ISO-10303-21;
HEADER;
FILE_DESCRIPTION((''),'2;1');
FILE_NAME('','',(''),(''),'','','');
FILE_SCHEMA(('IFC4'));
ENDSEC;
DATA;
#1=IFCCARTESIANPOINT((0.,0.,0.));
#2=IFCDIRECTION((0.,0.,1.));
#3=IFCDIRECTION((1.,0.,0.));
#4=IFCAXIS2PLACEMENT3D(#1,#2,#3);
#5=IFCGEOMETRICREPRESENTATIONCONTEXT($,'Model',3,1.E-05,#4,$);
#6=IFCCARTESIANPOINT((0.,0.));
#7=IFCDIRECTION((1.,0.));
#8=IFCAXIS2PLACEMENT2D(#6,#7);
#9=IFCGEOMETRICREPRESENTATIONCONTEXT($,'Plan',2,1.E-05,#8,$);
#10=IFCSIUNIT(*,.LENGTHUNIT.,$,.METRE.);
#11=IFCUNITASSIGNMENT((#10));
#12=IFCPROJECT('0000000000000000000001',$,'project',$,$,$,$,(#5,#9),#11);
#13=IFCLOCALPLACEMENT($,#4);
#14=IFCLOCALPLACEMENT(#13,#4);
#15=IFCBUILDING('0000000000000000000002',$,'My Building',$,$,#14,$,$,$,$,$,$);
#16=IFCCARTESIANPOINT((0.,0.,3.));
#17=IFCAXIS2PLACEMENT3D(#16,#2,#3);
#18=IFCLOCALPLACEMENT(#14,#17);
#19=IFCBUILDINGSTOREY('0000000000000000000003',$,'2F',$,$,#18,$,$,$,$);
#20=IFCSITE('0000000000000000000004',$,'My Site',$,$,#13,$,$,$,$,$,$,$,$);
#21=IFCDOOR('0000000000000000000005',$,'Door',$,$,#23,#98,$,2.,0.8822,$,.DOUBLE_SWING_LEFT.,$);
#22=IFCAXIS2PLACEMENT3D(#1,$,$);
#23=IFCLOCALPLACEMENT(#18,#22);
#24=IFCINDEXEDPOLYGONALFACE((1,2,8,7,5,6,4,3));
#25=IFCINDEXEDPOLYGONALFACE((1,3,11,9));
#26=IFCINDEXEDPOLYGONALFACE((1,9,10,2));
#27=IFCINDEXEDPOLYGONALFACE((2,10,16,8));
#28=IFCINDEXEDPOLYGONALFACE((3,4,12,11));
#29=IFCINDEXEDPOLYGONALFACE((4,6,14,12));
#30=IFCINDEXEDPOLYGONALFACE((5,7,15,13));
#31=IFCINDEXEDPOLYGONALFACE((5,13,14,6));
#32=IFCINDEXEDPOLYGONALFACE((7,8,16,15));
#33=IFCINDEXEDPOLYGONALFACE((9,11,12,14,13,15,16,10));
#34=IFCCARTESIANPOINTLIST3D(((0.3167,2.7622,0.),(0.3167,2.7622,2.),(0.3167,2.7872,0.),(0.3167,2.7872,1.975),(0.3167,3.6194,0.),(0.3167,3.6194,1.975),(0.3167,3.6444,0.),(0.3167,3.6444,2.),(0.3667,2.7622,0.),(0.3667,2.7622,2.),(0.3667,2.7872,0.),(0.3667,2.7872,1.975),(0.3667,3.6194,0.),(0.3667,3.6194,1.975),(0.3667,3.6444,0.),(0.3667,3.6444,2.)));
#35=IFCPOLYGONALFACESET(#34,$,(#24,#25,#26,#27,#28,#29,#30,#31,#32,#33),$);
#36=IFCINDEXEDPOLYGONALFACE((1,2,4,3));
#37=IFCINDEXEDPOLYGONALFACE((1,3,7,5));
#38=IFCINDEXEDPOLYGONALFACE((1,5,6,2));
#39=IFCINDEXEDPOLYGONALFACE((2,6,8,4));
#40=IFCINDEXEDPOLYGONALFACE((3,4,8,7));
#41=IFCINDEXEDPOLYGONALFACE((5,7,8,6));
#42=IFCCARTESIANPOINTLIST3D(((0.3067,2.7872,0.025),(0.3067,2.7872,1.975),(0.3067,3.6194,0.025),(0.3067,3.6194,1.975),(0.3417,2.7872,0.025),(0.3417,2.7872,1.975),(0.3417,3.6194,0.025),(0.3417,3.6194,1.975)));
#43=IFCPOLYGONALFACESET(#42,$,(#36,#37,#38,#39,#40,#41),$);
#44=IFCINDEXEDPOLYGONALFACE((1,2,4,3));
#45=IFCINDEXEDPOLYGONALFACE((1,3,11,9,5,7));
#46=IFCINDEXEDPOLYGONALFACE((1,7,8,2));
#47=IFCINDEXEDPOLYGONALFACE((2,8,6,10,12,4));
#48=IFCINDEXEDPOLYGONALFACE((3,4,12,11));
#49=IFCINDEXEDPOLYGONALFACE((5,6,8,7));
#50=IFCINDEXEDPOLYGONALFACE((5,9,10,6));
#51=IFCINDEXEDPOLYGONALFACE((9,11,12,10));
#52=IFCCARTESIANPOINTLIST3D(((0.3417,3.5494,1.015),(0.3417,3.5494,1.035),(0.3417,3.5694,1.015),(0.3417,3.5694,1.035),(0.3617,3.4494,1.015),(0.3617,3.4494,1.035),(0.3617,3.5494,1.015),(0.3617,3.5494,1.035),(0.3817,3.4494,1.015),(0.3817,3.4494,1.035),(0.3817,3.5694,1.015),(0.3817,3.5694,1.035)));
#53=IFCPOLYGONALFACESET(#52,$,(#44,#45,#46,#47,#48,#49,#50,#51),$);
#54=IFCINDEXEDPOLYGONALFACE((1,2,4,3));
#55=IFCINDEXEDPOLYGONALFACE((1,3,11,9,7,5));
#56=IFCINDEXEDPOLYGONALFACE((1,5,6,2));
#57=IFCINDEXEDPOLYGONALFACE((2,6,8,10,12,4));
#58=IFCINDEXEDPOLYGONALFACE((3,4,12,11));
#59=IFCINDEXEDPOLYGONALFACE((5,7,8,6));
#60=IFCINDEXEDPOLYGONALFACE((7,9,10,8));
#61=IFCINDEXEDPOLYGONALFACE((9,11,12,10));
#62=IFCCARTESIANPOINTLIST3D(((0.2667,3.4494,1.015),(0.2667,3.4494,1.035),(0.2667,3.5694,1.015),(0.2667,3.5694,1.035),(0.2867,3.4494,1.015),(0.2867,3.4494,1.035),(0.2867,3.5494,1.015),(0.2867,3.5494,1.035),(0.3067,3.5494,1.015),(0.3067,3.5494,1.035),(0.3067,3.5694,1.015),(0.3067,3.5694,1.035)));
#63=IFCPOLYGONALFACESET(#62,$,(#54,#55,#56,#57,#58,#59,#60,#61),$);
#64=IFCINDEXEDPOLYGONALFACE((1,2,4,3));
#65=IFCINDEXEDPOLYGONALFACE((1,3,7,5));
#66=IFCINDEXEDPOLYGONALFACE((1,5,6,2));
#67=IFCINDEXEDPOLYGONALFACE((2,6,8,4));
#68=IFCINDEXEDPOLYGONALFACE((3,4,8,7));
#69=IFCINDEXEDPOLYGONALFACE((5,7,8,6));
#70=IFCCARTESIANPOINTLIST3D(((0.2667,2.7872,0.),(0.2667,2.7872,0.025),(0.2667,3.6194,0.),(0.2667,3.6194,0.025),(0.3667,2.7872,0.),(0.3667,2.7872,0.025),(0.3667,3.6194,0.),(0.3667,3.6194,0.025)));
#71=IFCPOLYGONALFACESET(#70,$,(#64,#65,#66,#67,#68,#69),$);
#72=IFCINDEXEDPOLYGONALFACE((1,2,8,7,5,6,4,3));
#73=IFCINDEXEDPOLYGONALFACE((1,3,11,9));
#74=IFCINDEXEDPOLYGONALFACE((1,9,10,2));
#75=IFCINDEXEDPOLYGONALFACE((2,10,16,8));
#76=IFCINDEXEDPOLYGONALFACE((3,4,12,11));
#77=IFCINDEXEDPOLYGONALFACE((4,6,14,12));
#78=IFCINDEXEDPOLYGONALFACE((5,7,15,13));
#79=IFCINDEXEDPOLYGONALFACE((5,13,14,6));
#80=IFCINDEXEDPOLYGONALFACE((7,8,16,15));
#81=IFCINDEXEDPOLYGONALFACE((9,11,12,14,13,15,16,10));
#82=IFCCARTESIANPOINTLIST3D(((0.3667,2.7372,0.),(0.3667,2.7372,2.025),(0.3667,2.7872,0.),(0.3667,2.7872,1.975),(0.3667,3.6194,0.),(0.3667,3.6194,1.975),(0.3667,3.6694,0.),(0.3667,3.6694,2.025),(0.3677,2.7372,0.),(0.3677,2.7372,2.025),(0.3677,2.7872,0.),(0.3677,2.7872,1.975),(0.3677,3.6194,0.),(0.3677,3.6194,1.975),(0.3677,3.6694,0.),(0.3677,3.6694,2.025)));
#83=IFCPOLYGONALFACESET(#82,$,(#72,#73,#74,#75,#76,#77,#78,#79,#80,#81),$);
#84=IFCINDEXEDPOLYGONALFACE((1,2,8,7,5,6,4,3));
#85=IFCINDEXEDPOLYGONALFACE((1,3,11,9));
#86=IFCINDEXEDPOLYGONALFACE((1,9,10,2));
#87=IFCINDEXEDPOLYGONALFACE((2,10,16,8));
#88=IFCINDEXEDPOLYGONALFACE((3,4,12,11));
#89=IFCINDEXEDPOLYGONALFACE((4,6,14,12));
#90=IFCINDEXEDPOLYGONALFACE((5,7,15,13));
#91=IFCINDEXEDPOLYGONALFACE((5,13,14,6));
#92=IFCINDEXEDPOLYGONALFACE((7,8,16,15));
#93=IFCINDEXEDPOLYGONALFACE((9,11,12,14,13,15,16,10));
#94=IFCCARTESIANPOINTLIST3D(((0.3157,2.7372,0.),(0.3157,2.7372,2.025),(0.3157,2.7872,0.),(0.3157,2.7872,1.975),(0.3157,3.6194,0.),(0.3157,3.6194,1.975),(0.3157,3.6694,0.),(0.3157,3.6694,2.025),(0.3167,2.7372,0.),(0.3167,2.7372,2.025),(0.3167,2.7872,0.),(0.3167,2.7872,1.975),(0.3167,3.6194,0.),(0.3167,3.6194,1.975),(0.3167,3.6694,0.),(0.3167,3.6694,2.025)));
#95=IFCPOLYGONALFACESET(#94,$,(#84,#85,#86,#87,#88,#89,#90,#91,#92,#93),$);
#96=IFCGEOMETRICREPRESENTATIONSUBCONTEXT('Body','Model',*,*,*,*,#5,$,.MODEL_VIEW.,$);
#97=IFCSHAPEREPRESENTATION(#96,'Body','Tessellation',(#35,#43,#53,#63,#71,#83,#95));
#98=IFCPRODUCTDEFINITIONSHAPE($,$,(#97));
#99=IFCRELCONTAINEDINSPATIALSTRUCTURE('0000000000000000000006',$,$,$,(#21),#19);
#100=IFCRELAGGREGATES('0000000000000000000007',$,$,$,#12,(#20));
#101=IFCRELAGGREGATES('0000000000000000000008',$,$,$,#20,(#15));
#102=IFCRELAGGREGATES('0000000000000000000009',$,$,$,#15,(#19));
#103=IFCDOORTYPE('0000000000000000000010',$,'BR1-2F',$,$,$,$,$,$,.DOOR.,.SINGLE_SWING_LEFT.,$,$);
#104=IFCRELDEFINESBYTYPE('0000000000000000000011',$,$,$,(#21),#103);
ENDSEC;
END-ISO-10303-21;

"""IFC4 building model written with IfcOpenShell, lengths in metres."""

from ifc_helpers import new_model, entity, si_unit, frame, origin_with_axes, origin_2d_with_axis, place, context, subcontext, project, spatial, line, indexed_curve, outline, extrude, shape, source, transform, mapped, type_object, type_shapes, element, save


model = new_model("IFC4")

# Units and contexts
model_context = context("Model", 3, precision=1e-05, world=origin_with_axes())
plan_context = context("Plan", 2, precision=1e-05, world=origin_2d_with_axis())
body_context_1 = subcontext(model_context, "Body", "Model", "MODEL_VIEW")
body_context_2 = subcontext(plan_context, "Body", "Plan", "PLAN_VIEW")
ifc_project = project(units=[si_unit("LENGTHUNIT", "METRE")], contexts=[model_context, plan_context])

# Site, building, storey
site_placement = place(None, origin_with_axes())
site = spatial("IfcSite", under=ifc_project, at=site_placement, Name="My Site")
building_placement = place(site_placement, origin_with_axes())
building = spatial("IfcBuilding", under=site, at=building_placement, Name="My Building")
storey_placement = place(building_placement, frame((0.0, 0.0, 3.0), z_axis=(0.0, 0.0, 1.0), x_axis=(1.0, 0.0, 0.0)))
storey = spatial("IfcBuildingStorey", under=building, at=storey_placement, Name="2F")

# Door
door_type_1 = type_object("IfcDoorType", Name="BR1-2F", OperationType="SINGLE_SWING_LEFT", PredefinedType="DOOR")
shared_shape_1 = source(origin_with_axes(), body_context_1, "Body", "SweptSolid", [
    extrude(outline(indexed_curve([(0.0, 0.0), (0.0, 2.0), (0.8822, 2.0), (0.8822, 0.0), (0.8572, 0.0), (0.8572, 1.975), (0.025, 1.975), (0.025, 0.0)], segments=[line(1, 2, 3, 4, 5, 6, 7, 8, 1)])), frame((0.0, 0.0, 0.0), z_axis=(0.0, -1.0, 0.0), x_axis=(1.0, 0.0, 0.0)), (0.0, 0.0, -1.0), 0.05),
    extrude(outline(indexed_curve([(0.0, 0.0), (0.8322, 0.0), (0.8322, 0.035), (0.0, 0.035)], segments=[line(1, 2, 3, 4, 1)])), frame((0.025, 0.025, 0.025), z_axis=(0.0, 0.0, 1.0), x_axis=(1.0, 0.0, 0.0)), (0.0, 0.0, 1.0), 1.95),
    extrude(outline(indexed_curve([(0.0, 0.0), (0.0, -0.04), (-0.12, -0.04), (-0.12, -0.02), (-0.02, -0.02), (-0.02, 0.0)], segments=[line(1, 2, 3, 4, 5, 6, 1)])), frame((0.8072, 0.025, 1.015), z_axis=(0.0, 0.0, 1.0), x_axis=(1.0, 0.0, 0.0)), (0.0, 0.0, 1.0), 0.02),
    extrude(outline(indexed_curve([(0.0, 0.0), (0.0, 0.04), (-0.12, 0.04), (-0.12, 0.02), (-0.02, 0.02), (-0.02, 0.0)], segments=[line(1, 2, 3, 4, 5, 6, 1)])), frame((0.8072, 0.06, 1.015), z_axis=(0.0, 0.0, 1.0), x_axis=(1.0, 0.0, 0.0)), (0.0, 0.0, 1.0), 0.02),
    extrude(outline(indexed_curve([(0.0, 0.0), (0.8322, 0.0), (0.8322, 0.1), (0.0, 0.1)], segments=[line(1, 2, 3, 4, 1)])), frame((0.025, 0.0, 0.0), z_axis=(0.0, 0.0, 1.0), x_axis=(1.0, 0.0, 0.0)), (0.0, 0.0, 1.0), 0.025),
    extrude(outline(indexed_curve([(0.0, 0.0), (0.0, 2.025), (0.9322, 2.025), (0.9322, 0.0), (0.8822, 0.0), (0.8822, 1.975), (0.05, 1.975), (0.05, 0.0)], segments=[line(1, 2, 3, 4, 5, 6, 7, 8, 1)])), frame((-0.025, -0.001, 0.0), z_axis=(0.0, -1.0, 0.0), x_axis=(1.0, 0.0, 0.0)), (0.0, 0.0, -1.0), 0.001),
    extrude(outline(indexed_curve([(0.0, 0.0), (0.0, 2.025), (0.9322, 2.025), (0.9322, 0.0), (0.8822, 0.0), (0.8822, 1.975), (0.05, 1.975), (0.05, 0.0)], segments=[line(1, 2, 3, 4, 5, 6, 7, 8, 1)])), frame((-0.025, 0.05, 0.0), z_axis=(0.0, -1.0, 0.0), x_axis=(1.0, 0.0, 0.0)), (0.0, 0.0, -1.0), 0.001),
])
shared_shape_2 = source(origin_with_axes(), body_context_2, "Body", "Curve2D", [
    entity("IfcIndexedPolyCurve", entity("IfcCartesianPointList2D", [[0.0, 0.0], [0.025, 0.0], [0.025, 0.05], [0.0, 0.05]]), [entity("IfcLineIndex", [1, 2, 3, 4, 1])]),
    entity("IfcIndexedPolyCurve", entity("IfcCartesianPointList2D", [[0.8822, 0.0], [0.8572, 0.0], [0.8572, 0.05], [0.8822, 0.05]]), [entity("IfcLineIndex", [1, 2, 3, 4, 1])]),
    entity("IfcIndexedPolyCurve", entity("IfcCartesianPointList2D", [[0.025, 0.05], [0.025, -0.7822], [0.06, -0.7822]])),
    entity("IfcTrimmedCurve", entity("IfcEllipse", entity("IfcAxis2Placement2D", entity("IfcCartesianPoint", [0.06, 0.05]), entity("IfcDirection", [1.0, 0.0])), 0.7972, 0.8322), [entity("IfcCartesianPoint", [0.06, -0.7822])], [entity("IfcCartesianPoint", [0.06, 0.8822])], True, "CARTESIAN"),
    entity("IfcIndexedPolyCurve", entity("IfcCartesianPointList2D", [[0.025, 0.05], [0.06, 0.05], [0.06, 0.8822], [0.025, 0.8822]]), [entity("IfcLineIndex", [1, 2, 3, 4, 1])]),
])
type_shapes(door_type_1, [shared_shape_1, shared_shape_2])
placement_1 = place(storey_placement, frame((0.2817, 6.52, 0.0), z_axis=(0.0, 0.0, 1.0), x_axis=(0.0, -1.0, 0.0)))
placement_2 = place(placement_1, frame((3.7578, 0.085, 0.0), z_axis=(0.0, 0.0, 1.0), x_axis=(-1.0, 0.0, 0.0)))
door_1_placement = place(placement_2, frame((0.0, 0.0, 0.0), z_axis=(0.0, 0.0, 1.0), x_axis=(1.0, 0.0, 0.0)))
element("IfcDoor", 1, at=door_1_placement, inside=storey, type_object=door_type_1, Name="Door", OperationType="DOUBLE_SWING_LEFT", OverallHeight=2.0, OverallWidth=0.8822, shapes=[
    shape(body_context_1, "Body", "MappedRepresentation", [mapped(shared_shape_1, transform((0.0, 0.0, 0.0), x_axis=(1.0, 0.0, 0.0), y_axis=(0.0, 1.0, 0.0), z_axis=(0.0, 0.0, 1.0), scale=1.0))]),
    shape(body_context_2, "Body", "MappedRepresentation", [mapped(shared_shape_2, transform((0.0, 0.0, 0.0), x_axis=(1.0, 0.0, 0.0), y_axis=(0.0, 1.0, 0.0), z_axis=(0.0, 0.0, 1.0), scale=1.0))]),
])

save(model, "model.ifc")
